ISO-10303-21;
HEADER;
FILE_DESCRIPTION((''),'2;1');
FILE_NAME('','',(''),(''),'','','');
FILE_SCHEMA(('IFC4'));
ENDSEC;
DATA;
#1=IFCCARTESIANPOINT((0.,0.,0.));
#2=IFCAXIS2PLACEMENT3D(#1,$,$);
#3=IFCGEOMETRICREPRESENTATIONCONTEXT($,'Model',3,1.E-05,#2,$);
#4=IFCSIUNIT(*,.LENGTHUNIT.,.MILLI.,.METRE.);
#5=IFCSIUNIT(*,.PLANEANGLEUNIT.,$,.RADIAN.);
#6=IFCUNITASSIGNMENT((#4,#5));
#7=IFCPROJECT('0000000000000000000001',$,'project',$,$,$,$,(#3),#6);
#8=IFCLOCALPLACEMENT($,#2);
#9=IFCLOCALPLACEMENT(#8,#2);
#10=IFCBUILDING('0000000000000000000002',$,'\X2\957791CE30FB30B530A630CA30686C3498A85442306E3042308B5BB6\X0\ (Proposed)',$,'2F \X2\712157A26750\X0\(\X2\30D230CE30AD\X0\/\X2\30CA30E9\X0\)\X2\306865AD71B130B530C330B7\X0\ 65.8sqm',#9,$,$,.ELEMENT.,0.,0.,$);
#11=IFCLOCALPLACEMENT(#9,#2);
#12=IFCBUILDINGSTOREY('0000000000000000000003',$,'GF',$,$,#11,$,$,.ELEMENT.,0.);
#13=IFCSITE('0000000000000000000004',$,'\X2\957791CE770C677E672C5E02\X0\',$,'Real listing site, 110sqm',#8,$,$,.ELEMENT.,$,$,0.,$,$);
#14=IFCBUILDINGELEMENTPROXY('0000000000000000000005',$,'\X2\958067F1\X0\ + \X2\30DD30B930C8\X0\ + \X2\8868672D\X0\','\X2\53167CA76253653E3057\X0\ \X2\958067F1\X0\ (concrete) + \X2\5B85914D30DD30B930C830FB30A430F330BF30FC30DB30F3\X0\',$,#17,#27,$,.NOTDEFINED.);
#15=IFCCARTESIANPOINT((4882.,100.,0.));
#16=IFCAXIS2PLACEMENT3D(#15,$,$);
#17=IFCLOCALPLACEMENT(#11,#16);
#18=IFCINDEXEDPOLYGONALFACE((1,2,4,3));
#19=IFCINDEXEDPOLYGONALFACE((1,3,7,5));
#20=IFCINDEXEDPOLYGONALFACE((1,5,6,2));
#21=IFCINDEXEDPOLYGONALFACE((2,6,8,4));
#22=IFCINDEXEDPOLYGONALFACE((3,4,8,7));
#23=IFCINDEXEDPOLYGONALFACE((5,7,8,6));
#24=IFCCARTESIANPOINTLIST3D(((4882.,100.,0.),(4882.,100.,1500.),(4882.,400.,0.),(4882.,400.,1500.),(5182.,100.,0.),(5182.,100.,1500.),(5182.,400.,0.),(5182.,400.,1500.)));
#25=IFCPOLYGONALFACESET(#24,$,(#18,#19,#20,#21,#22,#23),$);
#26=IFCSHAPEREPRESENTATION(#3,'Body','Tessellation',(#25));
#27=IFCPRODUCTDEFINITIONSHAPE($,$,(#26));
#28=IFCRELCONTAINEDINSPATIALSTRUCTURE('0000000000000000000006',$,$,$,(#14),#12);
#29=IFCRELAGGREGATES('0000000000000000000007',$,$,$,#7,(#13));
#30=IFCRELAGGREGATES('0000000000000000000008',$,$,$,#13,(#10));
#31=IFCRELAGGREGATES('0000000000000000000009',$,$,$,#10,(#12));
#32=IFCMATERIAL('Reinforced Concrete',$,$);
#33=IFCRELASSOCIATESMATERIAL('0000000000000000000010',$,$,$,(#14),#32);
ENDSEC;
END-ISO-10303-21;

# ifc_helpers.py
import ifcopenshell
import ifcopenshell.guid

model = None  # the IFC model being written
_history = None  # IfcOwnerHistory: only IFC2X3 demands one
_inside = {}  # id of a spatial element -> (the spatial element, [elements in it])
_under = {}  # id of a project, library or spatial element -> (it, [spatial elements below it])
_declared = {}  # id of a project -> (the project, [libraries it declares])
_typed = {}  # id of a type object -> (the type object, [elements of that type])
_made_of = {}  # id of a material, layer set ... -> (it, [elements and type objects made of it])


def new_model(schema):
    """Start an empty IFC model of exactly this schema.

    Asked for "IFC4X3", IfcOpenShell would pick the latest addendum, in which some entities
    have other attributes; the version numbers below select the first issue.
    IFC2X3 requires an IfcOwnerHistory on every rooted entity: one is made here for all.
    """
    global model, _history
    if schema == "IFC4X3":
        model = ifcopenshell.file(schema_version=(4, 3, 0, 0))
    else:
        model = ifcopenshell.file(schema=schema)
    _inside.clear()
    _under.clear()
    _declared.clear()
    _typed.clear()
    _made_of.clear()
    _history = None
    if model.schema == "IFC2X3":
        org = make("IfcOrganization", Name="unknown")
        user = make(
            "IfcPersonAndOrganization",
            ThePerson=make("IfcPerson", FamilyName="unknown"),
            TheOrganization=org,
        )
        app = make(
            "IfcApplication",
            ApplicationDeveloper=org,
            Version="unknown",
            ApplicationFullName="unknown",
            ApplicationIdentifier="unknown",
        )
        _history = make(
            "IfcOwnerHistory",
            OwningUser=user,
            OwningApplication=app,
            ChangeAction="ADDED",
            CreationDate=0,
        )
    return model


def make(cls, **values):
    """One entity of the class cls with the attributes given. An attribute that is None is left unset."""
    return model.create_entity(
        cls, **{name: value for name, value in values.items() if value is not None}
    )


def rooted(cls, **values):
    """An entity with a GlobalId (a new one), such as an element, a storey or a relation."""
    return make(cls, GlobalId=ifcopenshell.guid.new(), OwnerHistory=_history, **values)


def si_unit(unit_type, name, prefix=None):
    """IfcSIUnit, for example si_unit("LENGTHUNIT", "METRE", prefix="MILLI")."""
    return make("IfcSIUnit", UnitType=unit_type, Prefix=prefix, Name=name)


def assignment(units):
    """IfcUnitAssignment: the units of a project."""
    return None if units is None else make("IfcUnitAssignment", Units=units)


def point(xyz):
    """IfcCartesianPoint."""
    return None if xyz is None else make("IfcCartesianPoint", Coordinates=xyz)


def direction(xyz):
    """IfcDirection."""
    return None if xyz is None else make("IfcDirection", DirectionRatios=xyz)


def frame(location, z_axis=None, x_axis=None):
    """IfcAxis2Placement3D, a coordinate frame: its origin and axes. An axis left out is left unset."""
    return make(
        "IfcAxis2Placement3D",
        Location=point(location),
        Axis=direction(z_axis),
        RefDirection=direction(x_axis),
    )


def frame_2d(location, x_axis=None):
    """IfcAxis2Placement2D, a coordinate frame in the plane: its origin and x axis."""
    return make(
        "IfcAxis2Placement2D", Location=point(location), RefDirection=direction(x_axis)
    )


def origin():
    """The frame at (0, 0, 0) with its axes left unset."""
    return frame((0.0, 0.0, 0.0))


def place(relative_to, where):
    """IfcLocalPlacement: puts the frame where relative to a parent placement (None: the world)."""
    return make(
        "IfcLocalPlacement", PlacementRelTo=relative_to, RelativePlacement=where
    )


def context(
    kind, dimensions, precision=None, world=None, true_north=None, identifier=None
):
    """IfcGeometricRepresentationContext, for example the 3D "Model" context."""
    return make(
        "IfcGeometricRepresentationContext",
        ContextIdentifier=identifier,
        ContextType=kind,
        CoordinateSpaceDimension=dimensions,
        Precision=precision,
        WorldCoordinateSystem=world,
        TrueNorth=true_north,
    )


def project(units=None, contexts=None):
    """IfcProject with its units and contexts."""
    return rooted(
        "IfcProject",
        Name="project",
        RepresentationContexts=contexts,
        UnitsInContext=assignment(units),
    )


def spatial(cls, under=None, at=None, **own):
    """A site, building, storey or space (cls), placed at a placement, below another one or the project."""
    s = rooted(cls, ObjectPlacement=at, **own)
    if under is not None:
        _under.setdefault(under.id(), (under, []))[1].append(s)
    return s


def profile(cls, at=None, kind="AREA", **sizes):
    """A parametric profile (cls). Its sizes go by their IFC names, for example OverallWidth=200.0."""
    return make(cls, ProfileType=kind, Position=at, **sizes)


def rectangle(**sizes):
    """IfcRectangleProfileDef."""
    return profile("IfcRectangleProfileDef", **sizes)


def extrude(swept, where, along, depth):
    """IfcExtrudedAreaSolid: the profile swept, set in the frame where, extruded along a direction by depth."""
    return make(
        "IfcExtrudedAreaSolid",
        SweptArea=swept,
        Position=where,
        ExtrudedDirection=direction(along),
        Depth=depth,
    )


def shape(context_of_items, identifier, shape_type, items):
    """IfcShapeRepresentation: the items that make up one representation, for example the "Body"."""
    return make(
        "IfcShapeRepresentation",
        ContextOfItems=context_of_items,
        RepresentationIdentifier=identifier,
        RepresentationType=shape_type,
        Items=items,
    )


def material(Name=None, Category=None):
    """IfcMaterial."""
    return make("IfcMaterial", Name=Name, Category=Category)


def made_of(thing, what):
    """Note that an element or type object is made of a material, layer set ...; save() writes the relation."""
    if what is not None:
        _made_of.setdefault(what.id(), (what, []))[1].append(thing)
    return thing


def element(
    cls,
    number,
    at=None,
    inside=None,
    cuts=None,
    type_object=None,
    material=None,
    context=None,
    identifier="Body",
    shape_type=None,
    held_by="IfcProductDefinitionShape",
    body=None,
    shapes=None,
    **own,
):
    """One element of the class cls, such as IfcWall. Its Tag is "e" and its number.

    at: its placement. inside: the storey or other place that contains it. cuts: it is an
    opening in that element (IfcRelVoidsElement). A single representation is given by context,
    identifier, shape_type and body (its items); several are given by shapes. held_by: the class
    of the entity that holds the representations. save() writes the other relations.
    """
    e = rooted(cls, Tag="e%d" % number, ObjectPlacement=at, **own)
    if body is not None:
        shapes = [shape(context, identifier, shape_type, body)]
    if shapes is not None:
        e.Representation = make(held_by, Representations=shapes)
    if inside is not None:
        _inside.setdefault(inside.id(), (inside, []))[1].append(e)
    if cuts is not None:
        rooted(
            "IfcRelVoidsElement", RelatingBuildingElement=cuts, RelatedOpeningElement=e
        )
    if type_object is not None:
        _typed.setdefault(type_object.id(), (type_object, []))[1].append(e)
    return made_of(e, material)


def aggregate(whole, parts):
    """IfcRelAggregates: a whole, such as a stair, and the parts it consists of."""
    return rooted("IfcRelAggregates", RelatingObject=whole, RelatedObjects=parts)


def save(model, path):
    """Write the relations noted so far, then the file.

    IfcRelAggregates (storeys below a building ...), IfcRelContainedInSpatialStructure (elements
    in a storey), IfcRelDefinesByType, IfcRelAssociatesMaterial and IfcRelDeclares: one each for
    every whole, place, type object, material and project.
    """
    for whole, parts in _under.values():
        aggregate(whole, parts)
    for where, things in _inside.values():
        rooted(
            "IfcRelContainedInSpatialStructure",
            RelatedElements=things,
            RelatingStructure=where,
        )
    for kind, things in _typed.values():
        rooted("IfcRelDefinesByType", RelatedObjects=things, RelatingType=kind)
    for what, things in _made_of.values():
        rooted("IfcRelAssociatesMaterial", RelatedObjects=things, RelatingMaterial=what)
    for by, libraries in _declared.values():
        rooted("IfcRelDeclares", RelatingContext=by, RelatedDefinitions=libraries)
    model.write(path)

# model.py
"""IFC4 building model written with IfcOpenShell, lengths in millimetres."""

from ifc_helpers import new_model, si_unit, frame, frame_2d, origin, place, context, project, spatial, rectangle, extrude, material, element, save


model = new_model("IFC4")

# Units and contexts
model_context = context("Model", 3, precision=1e-05, world=origin())
ifc_project = project(units=[si_unit("LENGTHUNIT", "METRE", prefix="MILLI"), si_unit("PLANEANGLEUNIT", "RADIAN")], contexts=[model_context])

# Site, building, storey
site_placement = place(None, origin())
site = spatial("IfcSite", under=ifc_project, at=site_placement, Name="長野県松本市", ObjectType="Real listing site, 110sqm", CompositionType="ELEMENT", RefElevation=0.0)
building_placement = place(site_placement, origin())
building = spatial("IfcBuilding", under=site, at=building_placement, Name="長野・サウナと水風呂のある家 (Proposed)", ObjectType="2F 無垢材(ヒノキ/ナラ)と断熱サッシ 65.8sqm", CompositionType="ELEMENT", ElevationOfRefHeight=0.0, ElevationOfTerrain=0.0)
storey_placement = place(building_placement, origin())
storey = spatial("IfcBuildingStorey", under=building, at=storey_placement, Name="GF", CompositionType="ELEMENT", Elevation=0.0)

# Shared definitions
ifc_material_1 = material(Name="Reinforced Concrete")

# Building element proxy
proxy_placement = place(storey_placement, frame((4882.0, 100.0, 0.0)))
element("IfcBuildingElementProxy", 1, at=proxy_placement, inside=storey, material=ifc_material_1, Name="門柱 + ポスト + 表札", Description="化粧打放し 門柱 (concrete) + 宅配ポスト・インターホン", PredefinedType="NOTDEFINED", context=model_context, shape_type="SweptSolid", body=[
    extrude(rectangle(XDim=300.0, YDim=300.0, at=frame_2d((150.0, 150.0))), frame((4882.0, 100.0, 0.0)), (0.0, 0.0, 1.0), 1500.0),
])

save(model, "model.ifc")
